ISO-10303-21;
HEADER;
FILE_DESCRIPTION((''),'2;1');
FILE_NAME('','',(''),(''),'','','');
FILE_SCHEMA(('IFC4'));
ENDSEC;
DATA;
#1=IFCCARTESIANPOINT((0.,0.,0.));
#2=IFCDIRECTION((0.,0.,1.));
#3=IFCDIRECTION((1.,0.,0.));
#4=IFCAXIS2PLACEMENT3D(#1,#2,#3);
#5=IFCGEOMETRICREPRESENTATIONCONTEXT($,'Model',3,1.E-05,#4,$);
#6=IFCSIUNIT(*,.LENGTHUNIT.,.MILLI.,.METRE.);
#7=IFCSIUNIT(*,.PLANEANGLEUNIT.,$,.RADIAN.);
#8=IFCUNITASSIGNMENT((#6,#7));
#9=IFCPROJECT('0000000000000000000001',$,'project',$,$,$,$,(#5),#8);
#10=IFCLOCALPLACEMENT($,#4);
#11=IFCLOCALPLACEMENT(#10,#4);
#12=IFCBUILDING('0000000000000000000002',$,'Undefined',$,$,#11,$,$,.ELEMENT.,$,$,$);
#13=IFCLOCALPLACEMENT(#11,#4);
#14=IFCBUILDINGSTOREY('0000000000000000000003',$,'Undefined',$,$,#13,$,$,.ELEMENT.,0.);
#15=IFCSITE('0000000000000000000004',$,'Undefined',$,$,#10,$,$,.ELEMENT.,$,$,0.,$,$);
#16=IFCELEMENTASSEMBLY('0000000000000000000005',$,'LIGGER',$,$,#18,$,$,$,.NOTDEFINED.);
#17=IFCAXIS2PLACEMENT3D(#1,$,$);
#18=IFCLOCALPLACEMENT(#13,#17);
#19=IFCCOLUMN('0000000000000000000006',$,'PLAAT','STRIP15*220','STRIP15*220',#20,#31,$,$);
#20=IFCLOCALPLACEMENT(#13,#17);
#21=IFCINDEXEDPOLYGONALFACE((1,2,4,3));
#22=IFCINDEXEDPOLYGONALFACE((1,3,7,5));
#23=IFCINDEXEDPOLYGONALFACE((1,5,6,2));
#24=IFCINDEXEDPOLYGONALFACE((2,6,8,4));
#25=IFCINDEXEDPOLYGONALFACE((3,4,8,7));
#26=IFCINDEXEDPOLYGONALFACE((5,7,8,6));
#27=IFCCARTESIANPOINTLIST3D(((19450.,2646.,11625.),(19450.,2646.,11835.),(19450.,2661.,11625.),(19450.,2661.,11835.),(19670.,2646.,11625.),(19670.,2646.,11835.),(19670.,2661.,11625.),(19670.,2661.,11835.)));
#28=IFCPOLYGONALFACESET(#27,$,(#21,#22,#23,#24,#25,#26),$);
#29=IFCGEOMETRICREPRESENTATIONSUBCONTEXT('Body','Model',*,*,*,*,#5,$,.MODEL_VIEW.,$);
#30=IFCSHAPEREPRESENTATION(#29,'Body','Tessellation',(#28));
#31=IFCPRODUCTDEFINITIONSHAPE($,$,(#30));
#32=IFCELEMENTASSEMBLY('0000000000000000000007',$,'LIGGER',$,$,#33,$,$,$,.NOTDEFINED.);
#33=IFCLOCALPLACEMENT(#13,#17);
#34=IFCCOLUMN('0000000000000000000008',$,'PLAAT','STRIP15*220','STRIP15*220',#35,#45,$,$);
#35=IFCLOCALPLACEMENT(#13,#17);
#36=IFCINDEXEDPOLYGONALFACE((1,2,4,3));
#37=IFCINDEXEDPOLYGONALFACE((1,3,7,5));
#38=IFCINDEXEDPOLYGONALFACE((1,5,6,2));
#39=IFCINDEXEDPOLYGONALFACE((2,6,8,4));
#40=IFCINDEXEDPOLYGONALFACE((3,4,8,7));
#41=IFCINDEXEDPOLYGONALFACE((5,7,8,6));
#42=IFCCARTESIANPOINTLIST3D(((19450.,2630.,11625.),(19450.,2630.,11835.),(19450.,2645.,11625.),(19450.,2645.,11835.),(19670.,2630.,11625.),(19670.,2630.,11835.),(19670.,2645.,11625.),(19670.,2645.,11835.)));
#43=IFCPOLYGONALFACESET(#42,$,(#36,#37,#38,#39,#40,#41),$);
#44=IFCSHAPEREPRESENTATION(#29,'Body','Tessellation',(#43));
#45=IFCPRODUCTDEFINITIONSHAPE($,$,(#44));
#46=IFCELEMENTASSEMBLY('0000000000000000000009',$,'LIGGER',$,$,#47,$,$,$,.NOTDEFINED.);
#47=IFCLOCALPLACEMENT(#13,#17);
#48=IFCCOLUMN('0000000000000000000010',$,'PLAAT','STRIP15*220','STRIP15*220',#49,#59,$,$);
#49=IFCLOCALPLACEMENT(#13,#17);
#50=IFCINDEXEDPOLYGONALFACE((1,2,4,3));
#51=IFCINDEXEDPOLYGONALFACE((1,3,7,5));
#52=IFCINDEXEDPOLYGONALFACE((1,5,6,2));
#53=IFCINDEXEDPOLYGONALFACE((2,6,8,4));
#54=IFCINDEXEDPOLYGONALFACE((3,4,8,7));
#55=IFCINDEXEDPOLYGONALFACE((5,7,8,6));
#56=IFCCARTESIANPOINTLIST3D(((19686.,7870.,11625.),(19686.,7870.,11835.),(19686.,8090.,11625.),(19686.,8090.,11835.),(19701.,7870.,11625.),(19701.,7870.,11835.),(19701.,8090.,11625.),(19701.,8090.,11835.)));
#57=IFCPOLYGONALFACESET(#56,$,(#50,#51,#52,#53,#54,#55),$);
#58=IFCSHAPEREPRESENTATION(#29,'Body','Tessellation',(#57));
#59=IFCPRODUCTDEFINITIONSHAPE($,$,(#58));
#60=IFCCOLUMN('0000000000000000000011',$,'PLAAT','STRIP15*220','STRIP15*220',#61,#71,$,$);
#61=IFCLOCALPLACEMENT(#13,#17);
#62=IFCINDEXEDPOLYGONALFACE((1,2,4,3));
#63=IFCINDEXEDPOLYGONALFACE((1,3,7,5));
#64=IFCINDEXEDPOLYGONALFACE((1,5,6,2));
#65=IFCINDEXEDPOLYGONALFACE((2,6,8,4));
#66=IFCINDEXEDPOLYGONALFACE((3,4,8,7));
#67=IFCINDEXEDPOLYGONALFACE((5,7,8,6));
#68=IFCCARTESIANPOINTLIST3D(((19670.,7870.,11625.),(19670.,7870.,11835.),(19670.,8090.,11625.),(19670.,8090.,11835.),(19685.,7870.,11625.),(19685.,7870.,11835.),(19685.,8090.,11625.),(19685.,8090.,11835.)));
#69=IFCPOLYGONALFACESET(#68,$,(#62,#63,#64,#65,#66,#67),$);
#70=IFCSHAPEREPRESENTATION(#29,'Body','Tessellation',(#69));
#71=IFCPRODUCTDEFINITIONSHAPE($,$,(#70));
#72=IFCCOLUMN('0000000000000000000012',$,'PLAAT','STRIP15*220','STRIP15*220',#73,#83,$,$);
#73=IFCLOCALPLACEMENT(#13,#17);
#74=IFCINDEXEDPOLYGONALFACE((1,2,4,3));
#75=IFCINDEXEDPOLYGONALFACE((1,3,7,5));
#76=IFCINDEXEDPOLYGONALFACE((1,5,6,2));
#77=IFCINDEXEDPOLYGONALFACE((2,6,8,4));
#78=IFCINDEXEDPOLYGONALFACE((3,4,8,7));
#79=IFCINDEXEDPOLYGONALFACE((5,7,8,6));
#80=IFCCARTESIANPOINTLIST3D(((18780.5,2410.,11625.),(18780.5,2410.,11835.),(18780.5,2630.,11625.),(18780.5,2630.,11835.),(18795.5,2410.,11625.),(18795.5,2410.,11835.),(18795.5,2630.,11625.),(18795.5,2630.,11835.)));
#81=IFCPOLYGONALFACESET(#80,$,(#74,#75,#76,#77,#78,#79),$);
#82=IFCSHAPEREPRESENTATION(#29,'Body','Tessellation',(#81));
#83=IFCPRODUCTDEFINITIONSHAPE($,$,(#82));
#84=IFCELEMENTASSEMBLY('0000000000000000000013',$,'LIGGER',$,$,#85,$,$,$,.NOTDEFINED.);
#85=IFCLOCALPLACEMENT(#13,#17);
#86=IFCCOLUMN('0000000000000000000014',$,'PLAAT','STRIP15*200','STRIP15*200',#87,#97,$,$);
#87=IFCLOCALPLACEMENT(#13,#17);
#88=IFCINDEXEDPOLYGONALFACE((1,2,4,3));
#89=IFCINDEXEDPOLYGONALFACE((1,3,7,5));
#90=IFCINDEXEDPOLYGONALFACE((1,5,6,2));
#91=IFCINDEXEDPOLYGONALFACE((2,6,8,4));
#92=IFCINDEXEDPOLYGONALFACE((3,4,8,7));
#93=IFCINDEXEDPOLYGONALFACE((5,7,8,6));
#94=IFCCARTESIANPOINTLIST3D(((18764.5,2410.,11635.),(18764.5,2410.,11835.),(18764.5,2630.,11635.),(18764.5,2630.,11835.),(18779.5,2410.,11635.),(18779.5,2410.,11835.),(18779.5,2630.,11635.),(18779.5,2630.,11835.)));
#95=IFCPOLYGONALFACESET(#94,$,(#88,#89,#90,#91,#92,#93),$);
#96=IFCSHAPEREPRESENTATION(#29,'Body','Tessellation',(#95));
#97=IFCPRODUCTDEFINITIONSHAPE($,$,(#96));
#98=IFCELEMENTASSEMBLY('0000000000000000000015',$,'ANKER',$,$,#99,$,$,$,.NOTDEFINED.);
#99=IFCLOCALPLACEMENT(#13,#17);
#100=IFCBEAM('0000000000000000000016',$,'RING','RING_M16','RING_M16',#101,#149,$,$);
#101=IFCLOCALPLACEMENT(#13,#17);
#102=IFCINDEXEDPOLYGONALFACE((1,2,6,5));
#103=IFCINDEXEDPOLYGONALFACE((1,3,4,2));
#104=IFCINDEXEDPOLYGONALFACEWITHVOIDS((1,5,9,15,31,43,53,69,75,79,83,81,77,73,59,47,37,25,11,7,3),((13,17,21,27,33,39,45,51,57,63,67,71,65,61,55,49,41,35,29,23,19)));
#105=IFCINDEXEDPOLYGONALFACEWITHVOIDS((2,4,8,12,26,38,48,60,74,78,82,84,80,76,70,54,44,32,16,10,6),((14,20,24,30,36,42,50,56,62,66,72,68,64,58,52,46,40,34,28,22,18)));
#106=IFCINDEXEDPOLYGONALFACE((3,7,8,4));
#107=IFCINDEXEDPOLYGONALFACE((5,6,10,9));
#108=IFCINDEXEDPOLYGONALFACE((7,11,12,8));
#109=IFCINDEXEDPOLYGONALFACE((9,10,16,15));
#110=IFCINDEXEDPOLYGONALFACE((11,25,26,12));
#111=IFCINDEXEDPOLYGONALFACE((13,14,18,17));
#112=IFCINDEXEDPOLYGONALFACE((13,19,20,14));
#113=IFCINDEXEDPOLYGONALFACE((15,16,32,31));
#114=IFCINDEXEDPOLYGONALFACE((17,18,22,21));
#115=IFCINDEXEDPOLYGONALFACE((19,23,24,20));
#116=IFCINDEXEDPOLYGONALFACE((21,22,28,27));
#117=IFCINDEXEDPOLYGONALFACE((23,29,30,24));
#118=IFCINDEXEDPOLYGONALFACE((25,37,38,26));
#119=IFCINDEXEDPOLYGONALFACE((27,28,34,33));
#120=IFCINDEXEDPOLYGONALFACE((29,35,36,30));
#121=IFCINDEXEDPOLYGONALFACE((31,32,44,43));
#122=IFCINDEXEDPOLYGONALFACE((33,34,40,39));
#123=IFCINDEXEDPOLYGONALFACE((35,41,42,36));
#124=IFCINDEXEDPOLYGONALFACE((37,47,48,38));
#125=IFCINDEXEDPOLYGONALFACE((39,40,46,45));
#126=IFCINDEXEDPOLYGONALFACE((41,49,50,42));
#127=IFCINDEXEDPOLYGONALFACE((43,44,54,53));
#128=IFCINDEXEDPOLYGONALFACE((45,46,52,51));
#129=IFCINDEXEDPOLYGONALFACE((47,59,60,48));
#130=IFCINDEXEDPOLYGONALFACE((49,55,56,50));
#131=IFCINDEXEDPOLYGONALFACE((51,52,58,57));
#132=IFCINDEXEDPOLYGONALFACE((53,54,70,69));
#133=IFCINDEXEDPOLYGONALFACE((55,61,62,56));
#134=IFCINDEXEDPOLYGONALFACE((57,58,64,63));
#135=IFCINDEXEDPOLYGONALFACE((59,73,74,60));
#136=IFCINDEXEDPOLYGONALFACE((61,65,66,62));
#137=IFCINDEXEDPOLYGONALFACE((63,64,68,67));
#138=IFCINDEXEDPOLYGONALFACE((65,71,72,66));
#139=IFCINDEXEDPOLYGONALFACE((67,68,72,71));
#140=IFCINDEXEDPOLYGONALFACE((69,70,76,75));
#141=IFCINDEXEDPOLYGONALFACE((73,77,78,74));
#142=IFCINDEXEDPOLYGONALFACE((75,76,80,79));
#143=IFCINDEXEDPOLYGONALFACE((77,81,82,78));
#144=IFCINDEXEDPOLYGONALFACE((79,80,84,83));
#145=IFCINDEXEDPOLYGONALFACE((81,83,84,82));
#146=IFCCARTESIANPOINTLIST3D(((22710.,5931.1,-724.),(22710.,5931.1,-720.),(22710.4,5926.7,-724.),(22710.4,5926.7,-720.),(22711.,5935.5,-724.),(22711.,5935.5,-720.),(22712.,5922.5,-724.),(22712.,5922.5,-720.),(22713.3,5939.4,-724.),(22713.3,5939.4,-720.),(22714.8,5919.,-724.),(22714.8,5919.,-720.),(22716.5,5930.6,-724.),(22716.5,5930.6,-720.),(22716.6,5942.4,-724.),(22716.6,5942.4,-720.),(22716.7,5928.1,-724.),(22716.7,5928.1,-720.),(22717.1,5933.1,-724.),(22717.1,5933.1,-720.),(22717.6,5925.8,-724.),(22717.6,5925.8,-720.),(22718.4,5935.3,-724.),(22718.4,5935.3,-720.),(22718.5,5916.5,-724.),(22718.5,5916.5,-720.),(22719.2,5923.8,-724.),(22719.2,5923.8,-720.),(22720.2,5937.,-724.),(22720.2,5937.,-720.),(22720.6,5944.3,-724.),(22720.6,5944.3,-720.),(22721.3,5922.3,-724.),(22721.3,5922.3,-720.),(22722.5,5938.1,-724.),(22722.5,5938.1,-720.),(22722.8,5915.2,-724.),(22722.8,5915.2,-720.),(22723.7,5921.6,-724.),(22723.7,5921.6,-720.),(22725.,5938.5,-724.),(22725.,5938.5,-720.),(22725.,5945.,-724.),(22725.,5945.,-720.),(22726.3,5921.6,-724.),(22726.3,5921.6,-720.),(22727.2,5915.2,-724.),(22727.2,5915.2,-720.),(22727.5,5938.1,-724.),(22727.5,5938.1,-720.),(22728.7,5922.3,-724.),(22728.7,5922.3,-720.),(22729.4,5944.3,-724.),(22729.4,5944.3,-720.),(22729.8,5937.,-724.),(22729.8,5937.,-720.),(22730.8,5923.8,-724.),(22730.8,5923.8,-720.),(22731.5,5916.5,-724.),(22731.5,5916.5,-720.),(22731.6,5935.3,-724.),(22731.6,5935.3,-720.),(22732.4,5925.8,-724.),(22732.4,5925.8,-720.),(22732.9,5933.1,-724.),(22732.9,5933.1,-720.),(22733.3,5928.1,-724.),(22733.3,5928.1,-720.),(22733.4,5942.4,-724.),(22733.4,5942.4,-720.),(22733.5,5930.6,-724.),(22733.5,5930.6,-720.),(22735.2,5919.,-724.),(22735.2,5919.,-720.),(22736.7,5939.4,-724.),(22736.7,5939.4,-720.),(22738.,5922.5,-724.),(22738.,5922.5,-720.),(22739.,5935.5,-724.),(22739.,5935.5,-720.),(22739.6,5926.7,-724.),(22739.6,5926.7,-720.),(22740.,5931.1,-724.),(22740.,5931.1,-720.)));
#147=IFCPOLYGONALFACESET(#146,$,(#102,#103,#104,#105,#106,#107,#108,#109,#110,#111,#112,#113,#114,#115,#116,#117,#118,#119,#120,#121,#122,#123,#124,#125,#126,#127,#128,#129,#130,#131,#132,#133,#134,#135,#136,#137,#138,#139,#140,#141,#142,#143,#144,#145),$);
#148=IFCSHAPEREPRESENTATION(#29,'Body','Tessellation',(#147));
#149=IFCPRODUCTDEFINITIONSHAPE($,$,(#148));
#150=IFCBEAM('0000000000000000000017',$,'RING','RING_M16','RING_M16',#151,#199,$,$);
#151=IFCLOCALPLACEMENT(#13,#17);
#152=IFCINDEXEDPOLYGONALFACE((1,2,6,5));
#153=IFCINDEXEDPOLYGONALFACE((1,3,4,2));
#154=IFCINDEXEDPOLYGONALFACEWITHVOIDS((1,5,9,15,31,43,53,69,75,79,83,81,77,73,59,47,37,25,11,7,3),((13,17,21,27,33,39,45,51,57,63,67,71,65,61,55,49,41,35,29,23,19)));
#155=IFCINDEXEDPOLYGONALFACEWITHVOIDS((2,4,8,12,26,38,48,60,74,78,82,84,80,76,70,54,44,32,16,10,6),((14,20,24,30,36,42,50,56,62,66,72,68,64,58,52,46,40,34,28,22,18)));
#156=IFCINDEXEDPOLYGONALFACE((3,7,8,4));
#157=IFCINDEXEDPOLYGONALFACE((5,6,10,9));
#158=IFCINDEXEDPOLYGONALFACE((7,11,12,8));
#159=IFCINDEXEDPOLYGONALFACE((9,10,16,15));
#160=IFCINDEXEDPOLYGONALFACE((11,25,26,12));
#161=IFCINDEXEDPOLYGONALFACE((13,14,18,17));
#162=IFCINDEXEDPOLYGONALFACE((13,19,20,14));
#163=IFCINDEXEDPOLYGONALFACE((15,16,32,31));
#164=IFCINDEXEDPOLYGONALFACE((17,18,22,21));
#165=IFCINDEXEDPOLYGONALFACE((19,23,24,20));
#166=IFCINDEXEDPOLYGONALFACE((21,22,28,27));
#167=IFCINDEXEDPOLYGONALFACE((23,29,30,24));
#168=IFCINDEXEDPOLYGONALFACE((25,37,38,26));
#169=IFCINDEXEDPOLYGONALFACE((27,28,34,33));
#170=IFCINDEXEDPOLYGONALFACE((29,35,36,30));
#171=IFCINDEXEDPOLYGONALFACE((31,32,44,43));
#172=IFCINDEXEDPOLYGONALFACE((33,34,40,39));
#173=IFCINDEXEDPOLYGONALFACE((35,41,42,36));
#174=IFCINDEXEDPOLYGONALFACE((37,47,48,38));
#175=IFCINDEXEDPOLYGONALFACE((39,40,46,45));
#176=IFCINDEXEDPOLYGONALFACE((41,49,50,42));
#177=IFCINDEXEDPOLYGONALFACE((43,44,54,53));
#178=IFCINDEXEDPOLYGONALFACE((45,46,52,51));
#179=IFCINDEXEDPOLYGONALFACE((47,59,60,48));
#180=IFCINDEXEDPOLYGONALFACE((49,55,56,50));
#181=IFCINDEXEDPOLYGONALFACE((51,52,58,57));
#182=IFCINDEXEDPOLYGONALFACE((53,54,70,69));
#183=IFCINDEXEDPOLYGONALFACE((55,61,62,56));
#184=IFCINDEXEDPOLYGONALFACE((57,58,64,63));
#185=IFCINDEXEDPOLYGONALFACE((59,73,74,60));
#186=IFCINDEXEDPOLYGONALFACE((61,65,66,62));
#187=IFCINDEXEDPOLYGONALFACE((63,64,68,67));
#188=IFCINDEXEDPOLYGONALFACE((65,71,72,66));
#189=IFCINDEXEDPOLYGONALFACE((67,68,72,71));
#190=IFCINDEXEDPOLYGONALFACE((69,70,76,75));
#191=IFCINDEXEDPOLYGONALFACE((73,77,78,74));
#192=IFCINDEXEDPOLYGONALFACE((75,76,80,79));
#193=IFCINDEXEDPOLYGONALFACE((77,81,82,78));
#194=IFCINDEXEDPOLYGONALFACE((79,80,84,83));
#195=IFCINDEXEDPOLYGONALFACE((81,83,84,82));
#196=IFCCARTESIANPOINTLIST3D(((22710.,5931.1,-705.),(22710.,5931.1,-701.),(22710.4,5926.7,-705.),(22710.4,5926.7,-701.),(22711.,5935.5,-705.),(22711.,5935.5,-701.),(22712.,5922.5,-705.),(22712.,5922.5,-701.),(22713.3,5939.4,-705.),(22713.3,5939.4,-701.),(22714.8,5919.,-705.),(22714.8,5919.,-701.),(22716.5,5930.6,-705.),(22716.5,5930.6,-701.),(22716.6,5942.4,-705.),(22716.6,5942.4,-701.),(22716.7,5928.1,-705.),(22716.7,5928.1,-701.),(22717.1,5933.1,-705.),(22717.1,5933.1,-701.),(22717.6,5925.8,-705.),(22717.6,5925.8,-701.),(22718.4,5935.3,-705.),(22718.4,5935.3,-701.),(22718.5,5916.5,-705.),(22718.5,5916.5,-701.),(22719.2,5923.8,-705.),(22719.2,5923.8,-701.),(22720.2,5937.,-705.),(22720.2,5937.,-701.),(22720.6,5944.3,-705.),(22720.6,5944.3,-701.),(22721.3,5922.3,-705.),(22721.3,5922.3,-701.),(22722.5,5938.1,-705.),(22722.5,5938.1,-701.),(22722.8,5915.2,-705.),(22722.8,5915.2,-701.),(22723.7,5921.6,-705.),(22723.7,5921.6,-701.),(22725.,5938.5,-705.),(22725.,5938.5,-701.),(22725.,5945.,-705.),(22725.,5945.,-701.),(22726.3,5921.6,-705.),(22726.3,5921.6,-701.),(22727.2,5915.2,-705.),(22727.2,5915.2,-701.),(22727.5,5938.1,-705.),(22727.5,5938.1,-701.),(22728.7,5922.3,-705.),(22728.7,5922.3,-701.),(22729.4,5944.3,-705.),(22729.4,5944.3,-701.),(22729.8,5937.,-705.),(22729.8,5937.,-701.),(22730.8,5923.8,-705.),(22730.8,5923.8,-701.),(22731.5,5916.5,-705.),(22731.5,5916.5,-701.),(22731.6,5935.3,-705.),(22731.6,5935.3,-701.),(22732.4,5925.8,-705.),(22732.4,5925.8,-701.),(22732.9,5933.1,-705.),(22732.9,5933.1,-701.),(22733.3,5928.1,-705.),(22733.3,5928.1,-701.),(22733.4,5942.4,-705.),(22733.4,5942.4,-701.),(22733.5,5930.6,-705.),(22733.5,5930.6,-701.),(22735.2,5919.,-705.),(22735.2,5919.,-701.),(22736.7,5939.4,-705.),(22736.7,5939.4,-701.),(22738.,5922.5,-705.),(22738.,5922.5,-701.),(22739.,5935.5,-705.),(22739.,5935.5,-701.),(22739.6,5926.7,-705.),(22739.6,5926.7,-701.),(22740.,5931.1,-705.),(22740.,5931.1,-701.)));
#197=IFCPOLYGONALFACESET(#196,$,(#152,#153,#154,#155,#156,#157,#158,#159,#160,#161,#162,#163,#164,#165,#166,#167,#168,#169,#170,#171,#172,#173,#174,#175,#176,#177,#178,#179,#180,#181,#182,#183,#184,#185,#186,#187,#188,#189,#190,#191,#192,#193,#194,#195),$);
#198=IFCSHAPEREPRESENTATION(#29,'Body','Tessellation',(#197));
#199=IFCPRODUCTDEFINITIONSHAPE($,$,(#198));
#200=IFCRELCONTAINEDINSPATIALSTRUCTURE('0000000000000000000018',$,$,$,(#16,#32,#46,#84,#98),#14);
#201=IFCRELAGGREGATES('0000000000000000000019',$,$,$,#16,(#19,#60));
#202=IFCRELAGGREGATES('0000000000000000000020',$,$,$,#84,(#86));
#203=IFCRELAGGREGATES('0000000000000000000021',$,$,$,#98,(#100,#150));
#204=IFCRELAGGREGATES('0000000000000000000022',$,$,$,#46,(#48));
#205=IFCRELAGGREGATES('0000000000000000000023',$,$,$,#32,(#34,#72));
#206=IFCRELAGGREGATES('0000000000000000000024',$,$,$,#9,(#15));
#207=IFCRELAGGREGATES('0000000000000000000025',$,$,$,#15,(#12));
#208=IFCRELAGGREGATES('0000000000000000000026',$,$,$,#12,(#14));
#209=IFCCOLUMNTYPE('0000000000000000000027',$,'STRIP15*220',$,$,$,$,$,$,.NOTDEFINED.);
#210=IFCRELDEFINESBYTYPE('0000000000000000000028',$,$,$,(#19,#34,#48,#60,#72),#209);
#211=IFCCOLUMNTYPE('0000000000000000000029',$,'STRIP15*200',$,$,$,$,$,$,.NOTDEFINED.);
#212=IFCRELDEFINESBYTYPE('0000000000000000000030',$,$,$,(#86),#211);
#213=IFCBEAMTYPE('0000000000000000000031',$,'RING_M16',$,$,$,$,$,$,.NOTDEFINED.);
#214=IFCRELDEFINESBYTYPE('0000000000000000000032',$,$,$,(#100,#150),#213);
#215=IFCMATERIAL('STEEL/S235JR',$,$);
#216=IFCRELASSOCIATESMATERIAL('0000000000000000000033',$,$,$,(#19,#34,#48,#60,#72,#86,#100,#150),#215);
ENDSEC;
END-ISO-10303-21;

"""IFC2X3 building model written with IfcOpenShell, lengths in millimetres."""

from ifc_helpers import new_model, si_unit, frame, origin_with_axes, origin_2d_with_axis, place, context, subcontext, project, spatial, rectangle, hollow_circle, extrude, material, type_object, element, aggregate, save


model = new_model("IFC2X3")

# Units and contexts
model_context = context("Model", 3, precision=1e-05, world=origin_with_axes())
body_context = subcontext(model_context, "Body", "Model", "MODEL_VIEW")
ifc_project = project(units=[si_unit("LENGTHUNIT", "METRE", prefix="MILLI"), si_unit("PLANEANGLEUNIT", "RADIAN")], contexts=[model_context])

# Site, building, storey
site_placement = place(None, origin_with_axes())
site = spatial("IfcSite", under=ifc_project, at=site_placement, Name="Undefined", CompositionType="ELEMENT", RefElevation=0.0)
building_placement = place(site_placement, origin_with_axes())
building = spatial("IfcBuilding", under=site, at=building_placement, Name="Undefined", CompositionType="ELEMENT")
storey_placement = place(building_placement, origin_with_axes())
storey = spatial("IfcBuildingStorey", under=building, at=storey_placement, Name="Undefined", CompositionType="ELEMENT", Elevation=0.0)

# Element assemblies, columns
assembly_1_placement = place(storey_placement, frame((19560.0, 13870.0, 11730.0), z_axis=(0.0, 0.0, 1.0), x_axis=(0.0, -1.0, 0.0)))
assembly_1 = element("IfcElementAssembly", 1, at=assembly_1_placement, inside=storey, Name="LIGGER", PredefinedType="NOTDEFINED")
ifc_material = material(Name="STEEL/S235JR")
column_type_1 = type_object("IfcColumnType", Name="STRIP15*220", PredefinedType="NOTDEFINED")
column_1_placement = place(storey_placement, frame((19560.0, 2653.5, 11625.0), z_axis=(0.0, 0.0, 1.0), x_axis=(1.0, 0.0, 0.0)))
column_1 = element("IfcColumn", 2, at=column_1_placement, type_object=column_type_1, material=ifc_material, Name="PLAAT", Description="STRIP15*220", ObjectType="STRIP15*220", context=body_context, shape_type="SweptSolid", body=[
    extrude(rectangle(XDim=15.0, YDim=220.0, at=origin_2d_with_axis()), frame((0.0, 0.0, 210.0), z_axis=(0.0, 0.0, -1.0), x_axis=(0.0, 1.0, 0.0)), (0.0, 0.0, 1.0), 210.0),
])
assembly_2_placement = place(storey_placement, frame((19819.0, 2520.0, 11793.5), z_axis=(0.906308, 0.0, 0.422618), x_axis=(0.422618, 0.0, -0.906308)))
assembly_2 = element("IfcElementAssembly", 3, at=assembly_2_placement, inside=storey, Name="LIGGER", PredefinedType="NOTDEFINED")
column_2_placement = place(storey_placement, frame((19560.0, 2637.5, 11625.0), z_axis=(0.0, 0.0, 1.0), x_axis=(1.0, 0.0, 0.0)))
column_2 = element("IfcColumn", 4, at=column_2_placement, type_object=column_type_1, material=ifc_material, Name="PLAAT", Description="STRIP15*220", ObjectType="STRIP15*220", context=body_context, shape_type="SweptSolid", body=[
    extrude(rectangle(XDim=15.0, YDim=220.0, at=origin_2d_with_axis()), frame((0.0, 0.0, 210.0), z_axis=(0.0, 0.0, -1.0), x_axis=(0.0, 1.0, 0.0)), (0.0, 0.0, 1.0), 210.0),
])
assembly_3_placement = place(storey_placement, frame((19819.0, 7980.0, 11793.5), z_axis=(0.906308, 0.0, 0.422618), x_axis=(0.422618, 0.0, -0.906308)))
assembly_3 = element("IfcElementAssembly", 5, at=assembly_3_placement, inside=storey, Name="LIGGER", PredefinedType="NOTDEFINED")
column_3_placement = place(storey_placement, frame((19693.5, 7980.0, 11625.0), z_axis=(0.0, 0.0, 1.0), x_axis=(1.0, 0.0, 0.0)))
column_3 = element("IfcColumn", 6, at=column_3_placement, type_object=column_type_1, material=ifc_material, Name="PLAAT", Description="STRIP15*220", ObjectType="STRIP15*220", context=body_context, shape_type="SweptSolid", body=[
    extrude(rectangle(XDim=15.0, YDim=220.0, at=origin_2d_with_axis()), frame((0.0, 0.0, 210.0), z_axis=(0.0, 0.0, -1.0), x_axis=(1.0, 0.0, 0.0)), (0.0, 0.0, 1.0), 210.0),
])

# Columns
column_4_placement = place(storey_placement, frame((19677.5, 7980.0, 11625.0), z_axis=(0.0, 0.0, 1.0), x_axis=(1.0, 0.0, 0.0)))
column_4 = element("IfcColumn", 7, at=column_4_placement, type_object=column_type_1, material=ifc_material, Name="PLAAT", Description="STRIP15*220", ObjectType="STRIP15*220", context=body_context, shape_type="SweptSolid", body=[
    extrude(rectangle(XDim=15.0, YDim=220.0, at=origin_2d_with_axis()), frame((0.0, 0.0, 210.0), z_axis=(0.0, 0.0, -1.0), x_axis=(1.0, 0.0, 0.0)), (0.0, 0.0, 1.0), 210.0),
])
aggregate(assembly_1, [column_1, column_4])
column_5_placement = place(storey_placement, frame((18788.0, 2520.0, 11625.0), z_axis=(0.0, 0.0, 1.0), x_axis=(1.0, 0.0, 0.0)))
column_5 = element("IfcColumn", 8, at=column_5_placement, type_object=column_type_1, material=ifc_material, Name="PLAAT", Description="STRIP15*220", ObjectType="STRIP15*220", context=body_context, shape_type="SweptSolid", body=[
    extrude(rectangle(XDim=15.0, YDim=220.0, at=origin_2d_with_axis()), frame((0.0, 0.0, 210.0), z_axis=(0.0, 0.0, -1.0), x_axis=(-1.0, 0.0, 0.0)), (0.0, 0.0, 1.0), 210.0),
])

# Element assembly, column
assembly_4_placement = place(storey_placement, frame((7820.0, 2520.0, 11735.0), z_axis=(0.0, 0.0, 1.0), x_axis=(1.0, 0.0, 0.0)))
assembly_4 = element("IfcElementAssembly", 9, at=assembly_4_placement, inside=storey, Name="LIGGER", PredefinedType="NOTDEFINED")
column_type_2 = type_object("IfcColumnType", Name="STRIP15*200", PredefinedType="NOTDEFINED")
column_6_placement = place(storey_placement, frame((18772.0, 2520.0, 11635.0), z_axis=(0.0, 0.0, 1.0), x_axis=(1.0, 0.0, 0.0)))
column_6 = element("IfcColumn", 10, at=column_6_placement, type_object=column_type_2, material=ifc_material, Name="PLAAT", Description="STRIP15*200", ObjectType="STRIP15*200", context=body_context, shape_type="SweptSolid", body=[
    extrude(rectangle(XDim=15.0, YDim=220.0, at=origin_2d_with_axis()), frame((0.0, 0.0, 200.0), z_axis=(0.0, 0.0, -1.0), x_axis=(-1.0, 0.0, 0.0)), (0.0, 0.0, 1.0), 200.0),
])
aggregate(assembly_4, [column_6])

# Element assembly, beams
assembly_5_placement = place(storey_placement, frame((22725.0, 5930.0, -655.0), z_axis=(-1.0, 0.0, 0.0), x_axis=(0.0, 0.0, -1.0)))
assembly_5 = element("IfcElementAssembly", 11, at=assembly_5_placement, inside=storey, Name="ANKER", PredefinedType="NOTDEFINED")
beam_type_1 = type_object("IfcBeamType", Name="RING_M16", PredefinedType="NOTDEFINED")
beam_1_placement = place(storey_placement, frame((22725.0, 5930.0, -720.0), z_axis=(-1.0, 0.0, 0.0), x_axis=(0.0, 0.0, -1.0)))
beam_1 = element("IfcBeam", 12, at=beam_1_placement, type_object=beam_type_1, material=ifc_material, Name="RING", Description="RING_M16", ObjectType="RING_M16", context=body_context, shape_type="SweptSolid", body=[
    extrude(hollow_circle(Radius=15.0, WallThickness=6.5, at=origin_2d_with_axis()), frame((4.0, 0.0, 0.0), z_axis=(-1.0, 0.0, 0.0), x_axis=(0.0, -1.0, 0.0)), (0.0, 0.0, 1.0), 4.0),
])
beam_2_placement = place(storey_placement, frame((22725.0, 5930.0, -701.0), z_axis=(-1.0, 0.0, 0.0), x_axis=(0.0, 0.0, -1.0)))
beam_2 = element("IfcBeam", 13, at=beam_2_placement, type_object=beam_type_1, material=ifc_material, Name="RING", Description="RING_M16", ObjectType="RING_M16", context=body_context, shape_type="SweptSolid", body=[
    extrude(hollow_circle(Radius=15.0, WallThickness=6.5, at=origin_2d_with_axis()), frame((4.0, 0.0, 0.0), z_axis=(-1.0, 0.0, 0.0), x_axis=(0.0, -1.0, 0.0)), (0.0, 0.0, 1.0), 4.0),
])
aggregate(assembly_5, [beam_1, beam_2])

aggregate(assembly_3, [column_3])
aggregate(assembly_2, [column_2, column_5])

save(model, "model.ifc")
